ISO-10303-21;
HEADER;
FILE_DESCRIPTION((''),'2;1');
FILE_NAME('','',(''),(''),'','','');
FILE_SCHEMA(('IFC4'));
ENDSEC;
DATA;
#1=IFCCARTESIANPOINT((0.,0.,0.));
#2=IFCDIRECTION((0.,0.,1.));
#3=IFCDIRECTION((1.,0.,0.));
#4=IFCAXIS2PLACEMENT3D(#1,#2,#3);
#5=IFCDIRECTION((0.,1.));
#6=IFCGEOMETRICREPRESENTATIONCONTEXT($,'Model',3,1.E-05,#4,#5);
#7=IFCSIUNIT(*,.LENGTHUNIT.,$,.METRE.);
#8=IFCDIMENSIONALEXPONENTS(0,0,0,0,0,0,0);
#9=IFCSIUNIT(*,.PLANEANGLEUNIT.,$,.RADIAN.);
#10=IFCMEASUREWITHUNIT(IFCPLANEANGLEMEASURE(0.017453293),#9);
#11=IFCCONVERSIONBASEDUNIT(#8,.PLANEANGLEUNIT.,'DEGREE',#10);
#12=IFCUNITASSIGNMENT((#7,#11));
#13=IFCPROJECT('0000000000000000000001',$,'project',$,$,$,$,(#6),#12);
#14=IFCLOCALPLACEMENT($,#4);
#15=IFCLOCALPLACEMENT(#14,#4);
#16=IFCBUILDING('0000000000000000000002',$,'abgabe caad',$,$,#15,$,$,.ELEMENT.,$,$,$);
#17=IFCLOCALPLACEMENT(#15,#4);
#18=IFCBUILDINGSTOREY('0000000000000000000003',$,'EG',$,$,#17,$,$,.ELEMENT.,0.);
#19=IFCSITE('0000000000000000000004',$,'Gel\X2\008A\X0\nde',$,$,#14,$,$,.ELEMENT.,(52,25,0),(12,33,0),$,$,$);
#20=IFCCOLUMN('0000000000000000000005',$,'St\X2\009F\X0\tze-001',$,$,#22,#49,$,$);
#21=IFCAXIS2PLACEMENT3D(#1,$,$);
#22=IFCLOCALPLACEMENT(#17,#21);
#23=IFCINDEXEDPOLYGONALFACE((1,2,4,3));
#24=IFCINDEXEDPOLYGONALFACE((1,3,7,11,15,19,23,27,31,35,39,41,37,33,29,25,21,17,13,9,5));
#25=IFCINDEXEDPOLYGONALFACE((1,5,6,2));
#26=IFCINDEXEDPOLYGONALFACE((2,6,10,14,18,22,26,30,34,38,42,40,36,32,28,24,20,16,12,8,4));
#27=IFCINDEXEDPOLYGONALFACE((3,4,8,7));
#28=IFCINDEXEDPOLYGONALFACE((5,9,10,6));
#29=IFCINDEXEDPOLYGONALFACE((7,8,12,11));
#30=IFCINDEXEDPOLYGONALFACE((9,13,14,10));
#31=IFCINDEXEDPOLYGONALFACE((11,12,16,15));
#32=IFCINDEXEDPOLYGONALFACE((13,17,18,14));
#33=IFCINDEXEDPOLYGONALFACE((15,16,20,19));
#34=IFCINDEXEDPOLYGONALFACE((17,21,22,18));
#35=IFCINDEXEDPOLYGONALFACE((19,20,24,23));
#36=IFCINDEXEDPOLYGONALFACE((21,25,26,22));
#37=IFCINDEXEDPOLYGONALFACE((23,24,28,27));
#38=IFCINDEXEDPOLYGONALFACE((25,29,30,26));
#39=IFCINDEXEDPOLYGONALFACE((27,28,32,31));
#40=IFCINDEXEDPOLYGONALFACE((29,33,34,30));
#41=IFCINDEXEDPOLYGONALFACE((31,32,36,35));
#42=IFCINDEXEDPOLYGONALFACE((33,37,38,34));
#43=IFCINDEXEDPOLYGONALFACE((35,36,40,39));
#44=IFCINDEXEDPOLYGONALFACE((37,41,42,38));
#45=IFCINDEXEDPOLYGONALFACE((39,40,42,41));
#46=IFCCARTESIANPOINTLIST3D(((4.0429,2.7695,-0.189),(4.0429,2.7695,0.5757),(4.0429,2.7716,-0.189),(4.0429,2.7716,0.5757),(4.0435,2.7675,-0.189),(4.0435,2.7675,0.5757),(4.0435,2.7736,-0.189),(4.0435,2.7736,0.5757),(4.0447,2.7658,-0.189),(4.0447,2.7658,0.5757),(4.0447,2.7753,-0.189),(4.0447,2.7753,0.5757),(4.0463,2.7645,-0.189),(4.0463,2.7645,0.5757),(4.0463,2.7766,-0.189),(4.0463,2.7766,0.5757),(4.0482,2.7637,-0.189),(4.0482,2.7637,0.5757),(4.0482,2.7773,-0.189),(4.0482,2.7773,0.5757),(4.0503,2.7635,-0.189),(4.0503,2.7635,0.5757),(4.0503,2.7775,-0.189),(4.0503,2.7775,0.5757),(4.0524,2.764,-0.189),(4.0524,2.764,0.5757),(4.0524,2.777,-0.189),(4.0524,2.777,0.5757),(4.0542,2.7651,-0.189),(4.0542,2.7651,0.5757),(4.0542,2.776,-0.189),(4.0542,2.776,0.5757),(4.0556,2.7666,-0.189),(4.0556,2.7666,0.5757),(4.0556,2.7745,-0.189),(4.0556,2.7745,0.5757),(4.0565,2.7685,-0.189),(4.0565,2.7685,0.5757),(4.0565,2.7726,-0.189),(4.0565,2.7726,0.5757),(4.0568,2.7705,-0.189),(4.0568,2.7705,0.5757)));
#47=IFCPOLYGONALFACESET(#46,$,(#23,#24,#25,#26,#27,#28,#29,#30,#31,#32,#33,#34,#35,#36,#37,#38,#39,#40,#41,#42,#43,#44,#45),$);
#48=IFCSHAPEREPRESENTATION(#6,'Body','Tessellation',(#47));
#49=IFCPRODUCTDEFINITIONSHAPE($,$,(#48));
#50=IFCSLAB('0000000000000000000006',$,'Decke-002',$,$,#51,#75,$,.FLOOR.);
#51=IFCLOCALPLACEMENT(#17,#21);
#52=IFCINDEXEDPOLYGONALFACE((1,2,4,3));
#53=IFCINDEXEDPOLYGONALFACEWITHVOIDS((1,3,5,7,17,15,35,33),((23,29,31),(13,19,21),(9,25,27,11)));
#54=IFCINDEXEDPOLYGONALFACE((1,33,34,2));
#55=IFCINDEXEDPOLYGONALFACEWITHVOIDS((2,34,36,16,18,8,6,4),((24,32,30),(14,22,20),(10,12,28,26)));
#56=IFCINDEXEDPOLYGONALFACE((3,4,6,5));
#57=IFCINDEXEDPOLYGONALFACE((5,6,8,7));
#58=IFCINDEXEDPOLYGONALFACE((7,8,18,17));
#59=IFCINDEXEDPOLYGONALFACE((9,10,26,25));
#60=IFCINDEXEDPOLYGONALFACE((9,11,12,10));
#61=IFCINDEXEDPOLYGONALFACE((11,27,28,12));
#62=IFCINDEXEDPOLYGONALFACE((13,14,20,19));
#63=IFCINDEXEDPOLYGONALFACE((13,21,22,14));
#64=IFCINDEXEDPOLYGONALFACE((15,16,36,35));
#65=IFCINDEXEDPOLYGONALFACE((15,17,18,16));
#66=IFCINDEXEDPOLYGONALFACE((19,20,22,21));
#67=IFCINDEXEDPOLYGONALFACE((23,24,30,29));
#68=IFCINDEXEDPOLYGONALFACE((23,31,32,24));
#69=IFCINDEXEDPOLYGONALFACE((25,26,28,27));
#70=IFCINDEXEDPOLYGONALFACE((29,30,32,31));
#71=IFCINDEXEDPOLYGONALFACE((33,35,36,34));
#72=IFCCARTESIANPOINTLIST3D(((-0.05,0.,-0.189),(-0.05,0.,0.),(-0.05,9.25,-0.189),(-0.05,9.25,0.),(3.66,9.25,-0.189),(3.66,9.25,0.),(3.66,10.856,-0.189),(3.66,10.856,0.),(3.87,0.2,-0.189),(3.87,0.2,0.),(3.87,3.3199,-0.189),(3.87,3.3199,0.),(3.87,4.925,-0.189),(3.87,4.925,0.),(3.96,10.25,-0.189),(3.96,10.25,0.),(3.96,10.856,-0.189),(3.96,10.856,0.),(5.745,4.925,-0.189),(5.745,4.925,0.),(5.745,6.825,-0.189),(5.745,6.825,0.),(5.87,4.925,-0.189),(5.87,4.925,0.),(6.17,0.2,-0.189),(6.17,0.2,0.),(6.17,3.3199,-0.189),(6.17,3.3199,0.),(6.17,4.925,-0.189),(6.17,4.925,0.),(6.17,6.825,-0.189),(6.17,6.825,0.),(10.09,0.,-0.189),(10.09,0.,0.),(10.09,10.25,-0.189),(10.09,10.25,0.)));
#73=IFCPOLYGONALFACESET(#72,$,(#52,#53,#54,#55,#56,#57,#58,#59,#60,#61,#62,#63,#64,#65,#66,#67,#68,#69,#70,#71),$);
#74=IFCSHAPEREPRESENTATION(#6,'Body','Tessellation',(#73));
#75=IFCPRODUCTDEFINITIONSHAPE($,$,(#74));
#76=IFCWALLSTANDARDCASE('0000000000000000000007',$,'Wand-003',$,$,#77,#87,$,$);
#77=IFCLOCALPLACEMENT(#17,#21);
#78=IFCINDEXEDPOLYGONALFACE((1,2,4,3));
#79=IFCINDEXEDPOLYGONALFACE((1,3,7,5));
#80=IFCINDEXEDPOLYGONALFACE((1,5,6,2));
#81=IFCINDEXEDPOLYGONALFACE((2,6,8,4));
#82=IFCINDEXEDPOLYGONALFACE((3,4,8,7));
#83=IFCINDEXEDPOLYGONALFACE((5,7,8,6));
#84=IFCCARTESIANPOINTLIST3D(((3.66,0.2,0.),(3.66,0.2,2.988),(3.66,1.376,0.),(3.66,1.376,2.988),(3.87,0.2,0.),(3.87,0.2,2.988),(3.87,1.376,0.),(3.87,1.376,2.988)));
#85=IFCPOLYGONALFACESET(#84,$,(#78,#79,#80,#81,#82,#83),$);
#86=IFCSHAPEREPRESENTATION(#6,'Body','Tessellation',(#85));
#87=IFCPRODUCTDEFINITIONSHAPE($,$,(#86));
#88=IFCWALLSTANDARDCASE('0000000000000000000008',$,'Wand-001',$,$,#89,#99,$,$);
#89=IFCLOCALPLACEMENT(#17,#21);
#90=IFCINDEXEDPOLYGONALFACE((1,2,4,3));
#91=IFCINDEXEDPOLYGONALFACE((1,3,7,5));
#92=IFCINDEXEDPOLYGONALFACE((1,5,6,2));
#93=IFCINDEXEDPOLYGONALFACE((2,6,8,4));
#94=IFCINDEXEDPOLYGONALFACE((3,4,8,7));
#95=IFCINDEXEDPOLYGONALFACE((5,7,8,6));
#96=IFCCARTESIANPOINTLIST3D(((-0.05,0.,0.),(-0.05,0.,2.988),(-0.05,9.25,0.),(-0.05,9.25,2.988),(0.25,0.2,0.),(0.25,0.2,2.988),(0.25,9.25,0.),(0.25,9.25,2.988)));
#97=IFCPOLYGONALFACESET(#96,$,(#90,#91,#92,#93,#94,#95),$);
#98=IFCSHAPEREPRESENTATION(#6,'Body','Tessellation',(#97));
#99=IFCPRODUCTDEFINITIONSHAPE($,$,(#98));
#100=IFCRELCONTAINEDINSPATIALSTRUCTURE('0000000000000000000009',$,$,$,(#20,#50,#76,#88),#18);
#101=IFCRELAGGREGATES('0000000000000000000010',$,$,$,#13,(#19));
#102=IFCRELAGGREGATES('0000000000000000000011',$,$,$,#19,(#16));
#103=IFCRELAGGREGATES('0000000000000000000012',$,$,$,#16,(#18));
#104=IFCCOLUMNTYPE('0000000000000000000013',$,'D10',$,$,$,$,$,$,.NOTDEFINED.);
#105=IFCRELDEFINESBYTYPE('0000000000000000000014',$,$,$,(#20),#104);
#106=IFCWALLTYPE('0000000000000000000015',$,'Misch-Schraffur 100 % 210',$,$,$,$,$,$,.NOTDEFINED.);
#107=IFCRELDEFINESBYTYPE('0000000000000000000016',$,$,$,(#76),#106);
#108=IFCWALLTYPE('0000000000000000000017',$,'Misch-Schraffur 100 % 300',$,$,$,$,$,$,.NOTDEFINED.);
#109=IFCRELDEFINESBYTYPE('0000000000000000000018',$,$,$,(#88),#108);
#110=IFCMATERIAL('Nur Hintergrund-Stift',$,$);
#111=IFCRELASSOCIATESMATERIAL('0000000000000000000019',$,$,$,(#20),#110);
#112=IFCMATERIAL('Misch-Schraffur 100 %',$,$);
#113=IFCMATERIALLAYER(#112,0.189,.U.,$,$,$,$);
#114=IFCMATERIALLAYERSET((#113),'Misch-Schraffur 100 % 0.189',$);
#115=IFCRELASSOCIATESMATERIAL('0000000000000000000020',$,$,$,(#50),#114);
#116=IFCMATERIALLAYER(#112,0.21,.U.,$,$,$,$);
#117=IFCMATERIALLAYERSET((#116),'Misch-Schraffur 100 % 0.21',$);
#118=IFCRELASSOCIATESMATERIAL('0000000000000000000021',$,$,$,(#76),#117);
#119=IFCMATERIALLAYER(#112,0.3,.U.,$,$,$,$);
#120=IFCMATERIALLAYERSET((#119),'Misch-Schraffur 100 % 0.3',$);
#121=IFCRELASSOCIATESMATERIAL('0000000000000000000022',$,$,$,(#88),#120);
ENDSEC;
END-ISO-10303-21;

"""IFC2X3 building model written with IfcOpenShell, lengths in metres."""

from ifc_helpers import new_model, entity, si_unit, converted_unit, direction, frame, origin_with_axes, origin_2d_with_axis, place, context, project, spatial, polyline, circle, outline, extrude, material, layer, layer_set, layer_usage, type_object, element, save


model = new_model("IFC2X3")

# Units and contexts
model_context = context("Model", 3, precision=1e-05, world=origin_with_axes(), true_north=direction((0.0, 1.0)))
ifc_project = project(units=[si_unit("LENGTHUNIT", "METRE"), converted_unit("PLANEANGLEUNIT", "DEGREE", entity("IfcPlaneAngleMeasure", 0.017453293), si_unit("PLANEANGLEUNIT", "RADIAN"), dimensions=[0, 0, 0, 0, 0, 0, 0])], contexts=[model_context])

# Site, building, storey
site_placement = place(None, origin_with_axes())
site = spatial("IfcSite", under=ifc_project, at=site_placement, Name="Gel\u008ande", CompositionType="ELEMENT", RefLatitude=(52, 25, 0), RefLongitude=(12, 33, 0))
building_placement = place(site_placement, origin_with_axes())
building = spatial("IfcBuilding", under=site, at=building_placement, Name="abgabe caad", CompositionType="ELEMENT")
storey_placement = place(building_placement, origin_with_axes())
storey = spatial("IfcBuildingStorey", under=building, at=storey_placement, Name="EG", CompositionType="ELEMENT", Elevation=0.0)

# Column
ifc_material_1 = material(Name="Nur Hintergrund-Stift")
column_type = type_object("IfcColumnType", Name="D10", PredefinedType="NOTDEFINED")
column_1_placement = place(storey_placement, frame((4.0498, 2.7705, -0.189), z_axis=(0.0, 0.0, 1.0), x_axis=(1.0, 0.0, 0.0)))
element("IfcColumn", 1, at=column_1_placement, inside=storey, type_object=column_type, material=ifc_material_1, Name="St\u009ftze-001", context=model_context, shape_type="SweptSolid", body=[
    extrude(circle(Radius=0.007, at=origin_2d_with_axis()), origin_with_axes(), (0.0, 0.0, 1.0), 0.7647),
])

# Slab
ifc_material_2 = material(Name="Misch-Schraffur 100 %")
ifc_layer_1 = layer(ifc_material_2, 0.189, ventilated="UNKNOWN")
ifc_layer_set_1 = layer_set([ifc_layer_1], Name="Misch-Schraffur 100 % 0.189")
ifc_layer_usage_1 = layer_usage(ifc_layer_set_1, "AXIS3", "NEGATIVE", 0.189)
slab_placement = place(storey_placement, frame((-0.05, 0.0, -0.189), z_axis=(0.0, 0.0, 1.0), x_axis=(1.0, 0.0, 0.0)))
element("IfcSlab", 2, at=slab_placement, inside=storey, material=ifc_layer_usage_1, Name="Decke-002", PredefinedType="FLOOR", context=model_context, shape_type="SweptSolid", body=[
    extrude(outline(polyline([(0.0, 0.0), (10.14, 0.0), (10.14, 10.25), (4.01, 10.25), (4.01, 10.856), (3.71, 10.856), (3.71, 9.25), (0.0, 9.25), (0.0, 0.0)]), holes=[polyline([(3.92, 0.2), (3.92, 3.3199), (6.22, 3.3199), (6.22, 0.2), (3.92, 0.2)]), polyline([(5.795, 6.825), (5.795, 4.925), (3.92, 4.925), (5.795, 6.825)]), polyline([(6.22, 6.825), (6.22, 4.925), (5.92, 4.925), (6.22, 6.825)])]), origin_with_axes(), (0.0, 0.0, 1.0), 0.189),
])

# Walls
ifc_layer_2 = layer(ifc_material_2, 0.21, ventilated="UNKNOWN")
ifc_layer_set_2 = layer_set([ifc_layer_2], Name="Misch-Schraffur 100 % 0.21")
ifc_layer_usage_2 = layer_usage(ifc_layer_set_2, "AXIS2", "NEGATIVE", 0.0)
wall_type_1 = type_object("IfcWallType", Name="Misch-Schraffur 100 % 210", PredefinedType="NOTDEFINED")
wall_1_placement = place(storey_placement, frame((3.66, 0.0, 0.0), z_axis=(0.0, 0.0, 1.0), x_axis=(0.0, 1.0, 0.0)))
element("IfcWallStandardCase", 3, at=wall_1_placement, inside=storey, type_object=wall_type_1, material=ifc_layer_usage_2, Name="Wand-003", context=model_context, shape_type="SweptSolid", body=[
    extrude(outline(polyline([(0.2, -0.21), (1.376, -0.21), (1.376, 0.0), (0.2, 0.0), (0.2, -0.21)])), origin_with_axes(), (0.0, 0.0, 1.0), 2.988),
])
ifc_layer_3 = layer(ifc_material_2, 0.3, ventilated="UNKNOWN")
ifc_layer_set_3 = layer_set([ifc_layer_3], Name="Misch-Schraffur 100 % 0.3")
ifc_layer_usage_3 = layer_usage(ifc_layer_set_3, "AXIS2", "NEGATIVE", 0.0)
wall_type_2 = type_object("IfcWallType", Name="Misch-Schraffur 100 % 300", PredefinedType="NOTDEFINED")
wall_2_placement = place(storey_placement, frame((-0.05, 0.0, 0.0), z_axis=(0.0, 0.0, 1.0), x_axis=(0.0, 1.0, 0.0)))
element("IfcWallStandardCase", 4, at=wall_2_placement, inside=storey, type_object=wall_type_2, material=ifc_layer_usage_3, Name="Wand-001", context=model_context, shape_type="SweptSolid", body=[
    extrude(outline(polyline([(0.2, -0.3), (9.25, -0.3), (9.25, 0.0), (0.0, 0.0), (0.2, -0.3)])), origin_with_axes(), (0.0, 0.0, 1.0), 2.988),
])

save(model, "model.ifc")
